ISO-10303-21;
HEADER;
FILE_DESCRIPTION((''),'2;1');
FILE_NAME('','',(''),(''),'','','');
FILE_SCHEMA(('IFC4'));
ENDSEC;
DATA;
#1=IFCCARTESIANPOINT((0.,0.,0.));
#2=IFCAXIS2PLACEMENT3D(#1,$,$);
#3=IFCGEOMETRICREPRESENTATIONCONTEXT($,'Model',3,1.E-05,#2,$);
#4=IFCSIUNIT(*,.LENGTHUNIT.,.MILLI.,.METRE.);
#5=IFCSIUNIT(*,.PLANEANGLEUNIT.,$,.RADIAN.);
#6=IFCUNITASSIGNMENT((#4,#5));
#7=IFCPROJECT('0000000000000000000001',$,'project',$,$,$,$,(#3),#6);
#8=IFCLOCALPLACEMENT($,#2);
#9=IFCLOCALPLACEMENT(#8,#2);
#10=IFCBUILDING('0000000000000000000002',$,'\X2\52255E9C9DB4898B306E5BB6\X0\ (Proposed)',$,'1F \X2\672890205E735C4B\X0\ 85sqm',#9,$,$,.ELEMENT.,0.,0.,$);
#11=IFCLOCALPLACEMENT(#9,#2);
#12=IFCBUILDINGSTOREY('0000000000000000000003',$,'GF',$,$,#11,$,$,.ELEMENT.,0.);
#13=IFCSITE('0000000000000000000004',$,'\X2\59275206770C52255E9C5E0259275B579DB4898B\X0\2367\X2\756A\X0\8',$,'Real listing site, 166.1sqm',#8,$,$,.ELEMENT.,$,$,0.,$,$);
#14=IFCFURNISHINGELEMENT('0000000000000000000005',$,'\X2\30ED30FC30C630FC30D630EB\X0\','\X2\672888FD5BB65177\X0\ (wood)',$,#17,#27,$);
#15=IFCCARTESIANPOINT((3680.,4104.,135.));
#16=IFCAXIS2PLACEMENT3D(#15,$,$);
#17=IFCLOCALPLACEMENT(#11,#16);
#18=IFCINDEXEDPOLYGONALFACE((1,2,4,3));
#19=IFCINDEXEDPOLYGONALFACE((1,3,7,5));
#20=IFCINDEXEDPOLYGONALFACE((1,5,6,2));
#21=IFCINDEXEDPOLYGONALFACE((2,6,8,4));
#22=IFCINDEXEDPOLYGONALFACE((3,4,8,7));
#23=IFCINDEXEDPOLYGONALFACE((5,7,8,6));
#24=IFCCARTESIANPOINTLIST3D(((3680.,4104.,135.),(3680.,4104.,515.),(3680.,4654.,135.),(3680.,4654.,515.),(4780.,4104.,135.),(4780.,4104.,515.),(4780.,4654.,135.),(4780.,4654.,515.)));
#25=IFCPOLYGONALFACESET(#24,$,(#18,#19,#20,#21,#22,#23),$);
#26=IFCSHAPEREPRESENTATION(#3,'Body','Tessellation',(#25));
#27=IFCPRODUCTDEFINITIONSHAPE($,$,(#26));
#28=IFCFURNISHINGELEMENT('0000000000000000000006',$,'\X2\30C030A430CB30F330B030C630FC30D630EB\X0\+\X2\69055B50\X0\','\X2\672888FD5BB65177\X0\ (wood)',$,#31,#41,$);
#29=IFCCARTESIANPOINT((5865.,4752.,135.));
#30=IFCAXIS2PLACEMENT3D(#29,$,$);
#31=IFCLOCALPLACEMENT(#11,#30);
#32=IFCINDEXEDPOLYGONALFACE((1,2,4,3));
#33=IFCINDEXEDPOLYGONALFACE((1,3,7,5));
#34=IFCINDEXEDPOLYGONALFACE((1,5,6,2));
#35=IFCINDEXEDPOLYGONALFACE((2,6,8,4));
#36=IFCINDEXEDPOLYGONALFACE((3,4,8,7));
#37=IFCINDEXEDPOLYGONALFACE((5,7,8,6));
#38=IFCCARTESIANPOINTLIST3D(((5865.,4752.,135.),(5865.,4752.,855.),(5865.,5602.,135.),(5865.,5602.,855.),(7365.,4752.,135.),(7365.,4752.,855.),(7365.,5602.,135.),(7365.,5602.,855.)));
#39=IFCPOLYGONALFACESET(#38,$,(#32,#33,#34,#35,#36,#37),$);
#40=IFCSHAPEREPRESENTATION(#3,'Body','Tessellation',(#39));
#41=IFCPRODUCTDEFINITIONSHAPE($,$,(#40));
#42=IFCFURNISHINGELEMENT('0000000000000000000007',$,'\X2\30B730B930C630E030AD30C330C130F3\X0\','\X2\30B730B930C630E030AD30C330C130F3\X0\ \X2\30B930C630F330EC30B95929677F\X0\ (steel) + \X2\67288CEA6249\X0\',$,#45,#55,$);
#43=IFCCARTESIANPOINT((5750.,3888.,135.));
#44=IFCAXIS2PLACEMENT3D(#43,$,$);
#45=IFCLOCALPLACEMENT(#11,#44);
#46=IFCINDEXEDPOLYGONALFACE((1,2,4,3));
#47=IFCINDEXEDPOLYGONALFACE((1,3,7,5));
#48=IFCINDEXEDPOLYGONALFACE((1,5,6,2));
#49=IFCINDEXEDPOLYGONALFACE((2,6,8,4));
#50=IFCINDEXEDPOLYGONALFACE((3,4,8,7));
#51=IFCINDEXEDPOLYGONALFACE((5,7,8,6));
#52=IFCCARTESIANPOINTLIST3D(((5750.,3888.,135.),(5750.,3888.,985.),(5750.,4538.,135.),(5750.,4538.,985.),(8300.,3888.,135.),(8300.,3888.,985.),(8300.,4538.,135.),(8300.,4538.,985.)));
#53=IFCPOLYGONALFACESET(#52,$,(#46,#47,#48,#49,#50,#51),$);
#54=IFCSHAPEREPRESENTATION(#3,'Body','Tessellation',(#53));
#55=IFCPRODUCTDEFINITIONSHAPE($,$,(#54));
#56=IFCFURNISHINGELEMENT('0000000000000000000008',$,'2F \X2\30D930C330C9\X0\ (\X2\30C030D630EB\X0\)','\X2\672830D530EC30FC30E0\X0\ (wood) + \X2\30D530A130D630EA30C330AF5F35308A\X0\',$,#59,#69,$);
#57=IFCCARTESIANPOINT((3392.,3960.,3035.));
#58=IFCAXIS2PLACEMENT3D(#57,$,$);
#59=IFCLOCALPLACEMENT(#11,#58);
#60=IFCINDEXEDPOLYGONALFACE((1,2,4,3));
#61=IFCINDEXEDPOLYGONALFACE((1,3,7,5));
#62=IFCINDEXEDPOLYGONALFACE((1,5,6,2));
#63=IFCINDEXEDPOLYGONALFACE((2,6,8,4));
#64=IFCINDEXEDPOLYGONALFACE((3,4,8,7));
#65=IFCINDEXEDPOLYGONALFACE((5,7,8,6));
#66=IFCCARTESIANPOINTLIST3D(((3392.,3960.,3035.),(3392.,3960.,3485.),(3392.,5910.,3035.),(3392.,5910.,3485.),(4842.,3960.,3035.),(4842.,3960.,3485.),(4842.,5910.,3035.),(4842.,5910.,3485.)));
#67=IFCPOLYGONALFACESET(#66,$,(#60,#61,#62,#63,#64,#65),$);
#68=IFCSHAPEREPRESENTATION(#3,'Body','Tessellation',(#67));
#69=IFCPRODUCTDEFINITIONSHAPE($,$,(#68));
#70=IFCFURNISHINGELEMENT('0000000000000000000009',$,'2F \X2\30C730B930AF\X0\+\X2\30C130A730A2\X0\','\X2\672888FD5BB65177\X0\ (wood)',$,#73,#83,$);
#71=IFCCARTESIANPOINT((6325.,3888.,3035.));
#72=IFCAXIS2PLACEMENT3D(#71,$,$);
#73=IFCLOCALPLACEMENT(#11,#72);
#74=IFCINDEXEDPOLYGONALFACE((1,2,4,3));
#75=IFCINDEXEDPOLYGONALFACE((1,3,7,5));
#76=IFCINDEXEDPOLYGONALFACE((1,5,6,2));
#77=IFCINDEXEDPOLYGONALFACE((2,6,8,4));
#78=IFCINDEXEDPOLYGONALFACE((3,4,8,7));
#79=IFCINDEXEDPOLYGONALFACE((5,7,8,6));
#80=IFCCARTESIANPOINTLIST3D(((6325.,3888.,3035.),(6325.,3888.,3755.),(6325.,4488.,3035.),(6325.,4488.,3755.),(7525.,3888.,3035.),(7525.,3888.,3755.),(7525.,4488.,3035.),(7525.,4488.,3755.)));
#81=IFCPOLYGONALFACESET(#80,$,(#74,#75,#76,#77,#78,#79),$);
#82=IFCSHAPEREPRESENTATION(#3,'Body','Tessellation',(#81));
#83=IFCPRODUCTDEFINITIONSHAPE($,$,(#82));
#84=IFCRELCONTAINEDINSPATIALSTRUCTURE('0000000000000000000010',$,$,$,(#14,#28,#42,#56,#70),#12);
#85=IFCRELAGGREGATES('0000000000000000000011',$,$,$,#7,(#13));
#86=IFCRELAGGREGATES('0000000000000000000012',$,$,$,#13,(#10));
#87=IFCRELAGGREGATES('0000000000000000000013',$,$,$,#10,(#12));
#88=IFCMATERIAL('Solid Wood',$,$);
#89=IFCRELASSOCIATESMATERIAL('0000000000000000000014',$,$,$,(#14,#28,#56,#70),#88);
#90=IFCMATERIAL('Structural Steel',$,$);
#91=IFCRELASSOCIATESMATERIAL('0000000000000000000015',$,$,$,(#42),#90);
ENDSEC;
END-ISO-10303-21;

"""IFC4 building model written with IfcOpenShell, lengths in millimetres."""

from ifc_helpers import new_model, si_unit, frame, frame_2d, origin, place, context, project, spatial, rectangle, extrude, material, element, save


model = new_model("IFC4")

# Units and contexts
model_context = context("Model", 3, precision=1e-05, world=origin())
ifc_project = project(units=[si_unit("LENGTHUNIT", "METRE", prefix="MILLI"), si_unit("PLANEANGLEUNIT", "RADIAN")], contexts=[model_context])

# Site, building, storey
site_placement = place(None, origin())
site = spatial("IfcSite", under=ifc_project, at=site_placement, Name="大分県別府市大字鶴見2367番8", ObjectType="Real listing site, 166.1sqm", CompositionType="ELEMENT", RefElevation=0.0)
building_placement = place(site_placement, origin())
building = spatial("IfcBuilding", under=site, at=building_placement, Name="別府鶴見の家 (Proposed)", ObjectType="1F 木造平屋 85sqm", CompositionType="ELEMENT", ElevationOfRefHeight=0.0, ElevationOfTerrain=0.0)
storey_placement = place(building_placement, origin())
storey = spatial("IfcBuildingStorey", under=building, at=storey_placement, Name="GF", CompositionType="ELEMENT", Elevation=0.0)

# Shared definitions
ifc_material_1 = material(Name="Solid Wood")

# Shared definitions
ifc_material_2 = material(Name="Structural Steel")

# Furnishing elements
furnishing_1_placement = place(storey_placement, frame((3680.0, 4104.0, 135.0)))
element("IfcFurnishingElement", 1, at=furnishing_1_placement, inside=storey, material=ifc_material_1, Name="ローテーブル", Description="木製家具 (wood)", context=model_context, shape_type="SweptSolid", body=[
    extrude(rectangle(XDim=1100.0, YDim=550.0, at=frame_2d((550.0, 275.0))), frame((3680.0, 4104.0, 135.0)), (0.0, 0.0, 1.0), 380.0),
])
furnishing_2_placement = place(storey_placement, frame((5865.0, 4752.0, 135.0)))
element("IfcFurnishingElement", 2, at=furnishing_2_placement, inside=storey, material=ifc_material_1, Name="ダイニングテーブル+椅子", Description="木製家具 (wood)", context=model_context, shape_type="SweptSolid", body=[
    extrude(rectangle(XDim=1500.0, YDim=850.0, at=frame_2d((750.0, 425.0))), frame((5865.0, 4752.0, 135.0)), (0.0, 0.0, 1.0), 720.0),
])
furnishing_3_placement = place(storey_placement, frame((5750.0, 3888.0, 135.0)))
element("IfcFurnishingElement", 3, at=furnishing_3_placement, inside=storey, material=ifc_material_2, Name="システムキッチン", Description="システムキッチン ステンレス天板 (steel) + 木質扉", context=model_context, shape_type="SweptSolid", body=[
    extrude(rectangle(XDim=2550.0, YDim=650.0, at=frame_2d((1275.0, 325.0))), frame((5750.0, 3888.0, 135.0)), (0.0, 0.0, 1.0), 850.0),
])
furnishing_4_placement = place(storey_placement, frame((3392.0, 3960.0, 3035.0)))
element("IfcFurnishingElement", 4, at=furnishing_4_placement, inside=storey, material=ifc_material_1, Name="2F ベッド (ダブル)", Description="木フレーム (wood) + ファブリック張り", context=model_context, shape_type="SweptSolid", body=[
    extrude(rectangle(XDim=1450.0, YDim=1950.0, at=frame_2d((725.0, 975.0))), frame((3392.0, 3960.0, 3035.0)), (0.0, 0.0, 1.0), 450.0),
])
furnishing_5_placement = place(storey_placement, frame((6325.0, 3888.0, 3035.0)))
element("IfcFurnishingElement", 5, at=furnishing_5_placement, inside=storey, material=ifc_material_1, Name="2F デスク+チェア", Description="木製家具 (wood)", context=model_context, shape_type="SweptSolid", body=[
    extrude(rectangle(XDim=1200.0, YDim=600.0, at=frame_2d((600.0, 300.0))), frame((6325.0, 3888.0, 3035.0)), (0.0, 0.0, 1.0), 720.0),
])

save(model, "model.ifc")
